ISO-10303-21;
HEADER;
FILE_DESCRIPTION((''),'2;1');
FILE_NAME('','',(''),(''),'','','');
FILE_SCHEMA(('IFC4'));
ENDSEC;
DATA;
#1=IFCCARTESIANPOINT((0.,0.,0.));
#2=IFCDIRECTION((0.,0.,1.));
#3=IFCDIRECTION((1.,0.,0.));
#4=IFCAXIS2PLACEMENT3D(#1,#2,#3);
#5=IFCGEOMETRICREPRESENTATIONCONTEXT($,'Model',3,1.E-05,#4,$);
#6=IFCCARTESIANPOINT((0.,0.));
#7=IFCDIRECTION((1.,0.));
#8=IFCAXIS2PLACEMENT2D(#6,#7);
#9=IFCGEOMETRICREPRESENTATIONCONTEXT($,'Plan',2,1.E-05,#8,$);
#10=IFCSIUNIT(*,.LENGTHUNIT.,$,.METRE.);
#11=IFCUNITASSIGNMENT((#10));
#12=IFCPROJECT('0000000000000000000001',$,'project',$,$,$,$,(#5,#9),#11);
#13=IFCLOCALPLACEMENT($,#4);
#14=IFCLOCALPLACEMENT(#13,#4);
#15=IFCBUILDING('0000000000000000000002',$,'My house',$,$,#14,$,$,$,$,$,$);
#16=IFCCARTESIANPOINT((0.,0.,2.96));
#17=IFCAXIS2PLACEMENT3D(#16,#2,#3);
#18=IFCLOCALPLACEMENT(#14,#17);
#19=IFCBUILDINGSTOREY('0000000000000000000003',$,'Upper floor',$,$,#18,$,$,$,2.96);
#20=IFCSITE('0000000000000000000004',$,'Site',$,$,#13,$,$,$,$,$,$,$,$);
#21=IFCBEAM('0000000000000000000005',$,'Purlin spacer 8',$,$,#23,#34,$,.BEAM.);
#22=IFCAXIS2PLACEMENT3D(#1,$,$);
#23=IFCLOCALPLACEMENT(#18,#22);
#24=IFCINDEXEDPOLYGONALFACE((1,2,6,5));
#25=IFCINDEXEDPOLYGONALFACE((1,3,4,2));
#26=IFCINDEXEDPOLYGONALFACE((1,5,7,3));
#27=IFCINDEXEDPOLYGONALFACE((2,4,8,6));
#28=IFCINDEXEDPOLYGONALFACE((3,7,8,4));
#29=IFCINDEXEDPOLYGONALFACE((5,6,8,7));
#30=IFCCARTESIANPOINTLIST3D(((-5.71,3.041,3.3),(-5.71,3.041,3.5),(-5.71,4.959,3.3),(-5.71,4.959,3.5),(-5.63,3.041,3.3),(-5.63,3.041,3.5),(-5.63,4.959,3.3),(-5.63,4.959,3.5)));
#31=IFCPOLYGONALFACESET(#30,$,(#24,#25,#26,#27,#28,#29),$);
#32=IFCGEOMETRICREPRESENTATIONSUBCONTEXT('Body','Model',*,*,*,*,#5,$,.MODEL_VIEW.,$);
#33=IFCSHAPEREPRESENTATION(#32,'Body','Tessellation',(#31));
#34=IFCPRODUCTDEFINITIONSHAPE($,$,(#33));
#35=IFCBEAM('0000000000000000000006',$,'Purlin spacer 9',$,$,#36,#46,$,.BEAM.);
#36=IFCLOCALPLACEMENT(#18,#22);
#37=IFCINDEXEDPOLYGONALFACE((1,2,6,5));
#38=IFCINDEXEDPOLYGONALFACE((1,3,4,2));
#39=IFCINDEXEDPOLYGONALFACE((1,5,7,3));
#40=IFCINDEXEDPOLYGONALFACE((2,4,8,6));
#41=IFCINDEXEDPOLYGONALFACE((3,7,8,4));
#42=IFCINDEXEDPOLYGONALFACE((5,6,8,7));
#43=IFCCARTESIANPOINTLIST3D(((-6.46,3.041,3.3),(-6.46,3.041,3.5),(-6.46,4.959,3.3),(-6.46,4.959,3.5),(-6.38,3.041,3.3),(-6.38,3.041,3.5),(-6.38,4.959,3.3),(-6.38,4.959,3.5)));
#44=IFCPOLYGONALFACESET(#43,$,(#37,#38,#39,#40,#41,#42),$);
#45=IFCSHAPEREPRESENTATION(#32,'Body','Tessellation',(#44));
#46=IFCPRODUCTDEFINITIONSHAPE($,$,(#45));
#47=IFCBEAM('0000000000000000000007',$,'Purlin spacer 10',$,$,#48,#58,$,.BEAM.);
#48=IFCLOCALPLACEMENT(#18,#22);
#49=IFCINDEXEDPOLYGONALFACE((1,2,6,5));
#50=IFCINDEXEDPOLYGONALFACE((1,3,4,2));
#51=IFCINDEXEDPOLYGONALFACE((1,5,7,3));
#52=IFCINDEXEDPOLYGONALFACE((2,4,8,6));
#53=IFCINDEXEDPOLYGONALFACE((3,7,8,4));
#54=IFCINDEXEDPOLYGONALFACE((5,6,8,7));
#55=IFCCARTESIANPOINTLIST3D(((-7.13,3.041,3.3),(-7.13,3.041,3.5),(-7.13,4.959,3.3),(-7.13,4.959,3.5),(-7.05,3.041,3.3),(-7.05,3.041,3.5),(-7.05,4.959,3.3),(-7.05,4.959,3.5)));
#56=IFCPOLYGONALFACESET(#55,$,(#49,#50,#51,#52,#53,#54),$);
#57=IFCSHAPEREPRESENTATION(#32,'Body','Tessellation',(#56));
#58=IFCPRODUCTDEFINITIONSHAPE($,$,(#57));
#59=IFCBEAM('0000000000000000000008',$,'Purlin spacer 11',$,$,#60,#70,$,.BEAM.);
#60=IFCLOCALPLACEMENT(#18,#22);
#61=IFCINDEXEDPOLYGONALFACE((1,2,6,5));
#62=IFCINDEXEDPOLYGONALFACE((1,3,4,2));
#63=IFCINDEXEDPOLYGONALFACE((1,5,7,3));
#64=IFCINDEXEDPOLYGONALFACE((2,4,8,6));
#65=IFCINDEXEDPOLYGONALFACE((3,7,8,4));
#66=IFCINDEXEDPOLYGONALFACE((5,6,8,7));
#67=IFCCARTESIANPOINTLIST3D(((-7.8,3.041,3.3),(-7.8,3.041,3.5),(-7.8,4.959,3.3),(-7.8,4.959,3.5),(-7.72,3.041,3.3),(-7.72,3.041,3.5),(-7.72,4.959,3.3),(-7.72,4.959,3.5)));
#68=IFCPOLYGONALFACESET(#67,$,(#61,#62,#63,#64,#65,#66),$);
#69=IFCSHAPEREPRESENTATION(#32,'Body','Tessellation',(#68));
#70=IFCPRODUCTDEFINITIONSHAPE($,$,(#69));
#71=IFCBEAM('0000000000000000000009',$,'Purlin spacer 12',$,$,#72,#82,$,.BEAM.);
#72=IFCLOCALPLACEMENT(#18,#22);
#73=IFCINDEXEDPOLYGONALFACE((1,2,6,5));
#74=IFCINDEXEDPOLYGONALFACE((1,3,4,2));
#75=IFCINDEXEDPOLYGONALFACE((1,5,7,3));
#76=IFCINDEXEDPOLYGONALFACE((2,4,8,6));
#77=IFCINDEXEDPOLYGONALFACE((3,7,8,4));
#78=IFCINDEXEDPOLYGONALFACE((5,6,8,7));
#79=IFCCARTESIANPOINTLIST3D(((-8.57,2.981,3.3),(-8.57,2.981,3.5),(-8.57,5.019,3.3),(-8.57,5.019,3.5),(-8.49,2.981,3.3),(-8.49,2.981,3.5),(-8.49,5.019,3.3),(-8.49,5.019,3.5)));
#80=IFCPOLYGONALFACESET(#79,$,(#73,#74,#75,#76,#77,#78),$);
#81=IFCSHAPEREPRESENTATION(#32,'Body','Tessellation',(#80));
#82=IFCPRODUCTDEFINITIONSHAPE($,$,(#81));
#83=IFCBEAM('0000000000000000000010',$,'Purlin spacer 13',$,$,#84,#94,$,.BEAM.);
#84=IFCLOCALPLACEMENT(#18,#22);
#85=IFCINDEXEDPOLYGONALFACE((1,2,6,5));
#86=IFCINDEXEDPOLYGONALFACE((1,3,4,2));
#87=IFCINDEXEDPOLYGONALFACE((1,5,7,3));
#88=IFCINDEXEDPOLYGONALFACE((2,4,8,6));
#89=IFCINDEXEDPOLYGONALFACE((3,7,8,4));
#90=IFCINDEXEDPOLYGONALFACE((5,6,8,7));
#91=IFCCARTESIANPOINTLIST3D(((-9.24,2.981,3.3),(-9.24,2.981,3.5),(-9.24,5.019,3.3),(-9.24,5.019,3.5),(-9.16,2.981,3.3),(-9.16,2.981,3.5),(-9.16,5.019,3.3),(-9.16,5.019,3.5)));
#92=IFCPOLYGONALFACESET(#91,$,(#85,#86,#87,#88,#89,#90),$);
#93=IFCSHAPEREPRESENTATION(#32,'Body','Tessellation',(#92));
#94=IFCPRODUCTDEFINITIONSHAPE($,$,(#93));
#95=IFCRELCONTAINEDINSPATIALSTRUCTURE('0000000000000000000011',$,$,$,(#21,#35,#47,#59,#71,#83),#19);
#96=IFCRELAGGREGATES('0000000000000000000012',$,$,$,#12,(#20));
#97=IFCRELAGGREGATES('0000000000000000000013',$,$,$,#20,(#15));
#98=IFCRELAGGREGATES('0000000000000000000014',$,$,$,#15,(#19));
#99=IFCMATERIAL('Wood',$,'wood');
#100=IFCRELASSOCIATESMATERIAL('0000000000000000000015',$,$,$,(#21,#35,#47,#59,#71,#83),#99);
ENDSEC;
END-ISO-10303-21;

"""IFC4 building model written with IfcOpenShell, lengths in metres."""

from ifc_helpers import new_model, si_unit, frame, origin_with_axes, origin_2d_with_axis, place, context, subcontext, project, spatial, rectangle, extrude, source, transform, mapped, material, element, save


model = new_model("IFC4")

# Units and contexts
model_context = context("Model", 3, precision=1e-05, world=origin_with_axes())
plan_context = context("Plan", 2, precision=1e-05, world=origin_2d_with_axis())
body_context_1 = subcontext(model_context, "Body", "Model", "MODEL_VIEW")
ifc_project = project(units=[si_unit("LENGTHUNIT", "METRE")], contexts=[model_context, plan_context])

# Site, building, storey
site_placement = place(None, origin_with_axes())
site = spatial("IfcSite", under=ifc_project, at=site_placement, Name="Site")
building_placement = place(site_placement, origin_with_axes())
building = spatial("IfcBuilding", under=site, at=building_placement, Name="My house")
storey_placement = place(building_placement, frame((0.0, 0.0, 2.96), z_axis=(0.0, 0.0, 1.0), x_axis=(1.0, 0.0, 0.0)))
storey = spatial("IfcBuildingStorey", under=building, at=storey_placement, Name="Upper floor", Elevation=2.96)

# Shared definitions
ifc_material_1 = material(Name="Wood", Category="wood")

# Beams
shared_shape_1 = source(origin_with_axes(), body_context_1, "Body", "SweptSolid", [
    extrude(rectangle(XDim=0.08, YDim=0.2), frame((0.0, 0.0, 0.0), z_axis=(1.0, 0.0, 0.0), x_axis=(0.0, 1.0, 0.0)), (0.0, 0.0, 1.0), 1.918),
])
beam_1_placement = place(storey_placement, frame((-5.67, 3.041, 3.4), z_axis=(0.0, 0.0, 1.0), x_axis=(0.0, -1.0, 0.0)))
element("IfcBeam", 1, at=beam_1_placement, inside=storey, material=ifc_material_1, Name="Purlin spacer 8", PredefinedType="BEAM", context=body_context_1, shape_type="MappedRepresentation", body=[
    mapped(shared_shape_1, transform((0.0, 0.0, 0.0), x_axis=(-1.0, 0.0, 0.0), y_axis=(0.0, 1.0, 0.0), z_axis=(0.0, 0.0, 1.0), scale=1.0)),
])
shared_shape_2 = source(origin_with_axes(), body_context_1, "Body", "SweptSolid", [
    extrude(rectangle(XDim=0.08, YDim=0.2), frame((0.0, 0.0, 0.0), z_axis=(1.0, 0.0, 0.0), x_axis=(0.0, 1.0, 0.0)), (0.0, 0.0, 1.0), 1.918),
])
beam_2_placement = place(storey_placement, frame((-6.42, 3.041, 3.4), z_axis=(0.0, 0.0, 1.0), x_axis=(0.0, -1.0, 0.0)))
element("IfcBeam", 2, at=beam_2_placement, inside=storey, material=ifc_material_1, Name="Purlin spacer 9", PredefinedType="BEAM", context=body_context_1, shape_type="MappedRepresentation", body=[
    mapped(shared_shape_2, transform((0.0, 0.0, 0.0), x_axis=(-1.0, 0.0, 0.0), y_axis=(0.0, 1.0, 0.0), z_axis=(0.0, 0.0, 1.0), scale=1.0)),
])
shared_shape_3 = source(origin_with_axes(), body_context_1, "Body", "SweptSolid", [
    extrude(rectangle(XDim=0.08, YDim=0.2), frame((0.0, 0.0, 0.0), z_axis=(1.0, 0.0, 0.0), x_axis=(0.0, 1.0, 0.0)), (0.0, 0.0, 1.0), 1.918),
])
beam_3_placement = place(storey_placement, frame((-7.09, 3.041, 3.4), z_axis=(0.0, 0.0, 1.0), x_axis=(0.0, -1.0, 0.0)))
element("IfcBeam", 3, at=beam_3_placement, inside=storey, material=ifc_material_1, Name="Purlin spacer 10", PredefinedType="BEAM", context=body_context_1, shape_type="MappedRepresentation", body=[
    mapped(shared_shape_3, transform((0.0, 0.0, 0.0), x_axis=(-1.0, 0.0, 0.0), y_axis=(0.0, 1.0, 0.0), z_axis=(0.0, 0.0, 1.0), scale=1.0)),
])
shared_shape_4 = source(origin_with_axes(), body_context_1, "Body", "SweptSolid", [
    extrude(rectangle(XDim=0.08, YDim=0.2), frame((0.0, 0.0, 0.0), z_axis=(1.0, 0.0, 0.0), x_axis=(0.0, 1.0, 0.0)), (0.0, 0.0, 1.0), 1.918),
])
beam_4_placement = place(storey_placement, frame((-7.76, 3.041, 3.4), z_axis=(0.0, 0.0, 1.0), x_axis=(0.0, -1.0, 0.0)))
element("IfcBeam", 4, at=beam_4_placement, inside=storey, material=ifc_material_1, Name="Purlin spacer 11", PredefinedType="BEAM", context=body_context_1, shape_type="MappedRepresentation", body=[
    mapped(shared_shape_4, transform((0.0, 0.0, 0.0), x_axis=(-1.0, 0.0, 0.0), y_axis=(0.0, 1.0, 0.0), z_axis=(0.0, 0.0, 1.0), scale=1.0)),
])
shared_shape_5 = source(origin_with_axes(), body_context_1, "Body", "SweptSolid", [
    extrude(rectangle(XDim=0.08, YDim=0.2), frame((0.0, 0.0, 0.0), z_axis=(1.0, 0.0, 0.0), x_axis=(0.0, 1.0, 0.0)), (0.0, 0.0, 1.0), 2.038),
])
beam_5_placement = place(storey_placement, frame((-8.53, 2.981, 3.4), z_axis=(0.0, 0.0, 1.0), x_axis=(0.0, -1.0, 0.0)))
element("IfcBeam", 5, at=beam_5_placement, inside=storey, material=ifc_material_1, Name="Purlin spacer 12", PredefinedType="BEAM", context=body_context_1, shape_type="MappedRepresentation", body=[
    mapped(shared_shape_5, transform((0.0, 0.0, 0.0), x_axis=(-1.0, 0.0, 0.0), y_axis=(0.0, 1.0, 0.0), z_axis=(0.0, 0.0, 1.0), scale=1.0)),
])
shared_shape_6 = source(origin_with_axes(), body_context_1, "Body", "SweptSolid", [
    extrude(rectangle(XDim=0.08, YDim=0.2), frame((0.0, 0.0, 0.0), z_axis=(1.0, 0.0, 0.0), x_axis=(0.0, 1.0, 0.0)), (0.0, 0.0, 1.0), 2.038),
])
beam_6_placement = place(storey_placement, frame((-9.2, 2.981, 3.4), z_axis=(0.0, 0.0, 1.0), x_axis=(0.0, -1.0, 0.0)))
element("IfcBeam", 6, at=beam_6_placement, inside=storey, material=ifc_material_1, Name="Purlin spacer 13", PredefinedType="BEAM", context=body_context_1, shape_type="MappedRepresentation", body=[
    mapped(shared_shape_6, transform((0.0, 0.0, 0.0), x_axis=(-1.0, 0.0, 0.0), y_axis=(0.0, 1.0, 0.0), z_axis=(0.0, 0.0, 1.0), scale=1.0)),
])

save(model, "model.ifc")
